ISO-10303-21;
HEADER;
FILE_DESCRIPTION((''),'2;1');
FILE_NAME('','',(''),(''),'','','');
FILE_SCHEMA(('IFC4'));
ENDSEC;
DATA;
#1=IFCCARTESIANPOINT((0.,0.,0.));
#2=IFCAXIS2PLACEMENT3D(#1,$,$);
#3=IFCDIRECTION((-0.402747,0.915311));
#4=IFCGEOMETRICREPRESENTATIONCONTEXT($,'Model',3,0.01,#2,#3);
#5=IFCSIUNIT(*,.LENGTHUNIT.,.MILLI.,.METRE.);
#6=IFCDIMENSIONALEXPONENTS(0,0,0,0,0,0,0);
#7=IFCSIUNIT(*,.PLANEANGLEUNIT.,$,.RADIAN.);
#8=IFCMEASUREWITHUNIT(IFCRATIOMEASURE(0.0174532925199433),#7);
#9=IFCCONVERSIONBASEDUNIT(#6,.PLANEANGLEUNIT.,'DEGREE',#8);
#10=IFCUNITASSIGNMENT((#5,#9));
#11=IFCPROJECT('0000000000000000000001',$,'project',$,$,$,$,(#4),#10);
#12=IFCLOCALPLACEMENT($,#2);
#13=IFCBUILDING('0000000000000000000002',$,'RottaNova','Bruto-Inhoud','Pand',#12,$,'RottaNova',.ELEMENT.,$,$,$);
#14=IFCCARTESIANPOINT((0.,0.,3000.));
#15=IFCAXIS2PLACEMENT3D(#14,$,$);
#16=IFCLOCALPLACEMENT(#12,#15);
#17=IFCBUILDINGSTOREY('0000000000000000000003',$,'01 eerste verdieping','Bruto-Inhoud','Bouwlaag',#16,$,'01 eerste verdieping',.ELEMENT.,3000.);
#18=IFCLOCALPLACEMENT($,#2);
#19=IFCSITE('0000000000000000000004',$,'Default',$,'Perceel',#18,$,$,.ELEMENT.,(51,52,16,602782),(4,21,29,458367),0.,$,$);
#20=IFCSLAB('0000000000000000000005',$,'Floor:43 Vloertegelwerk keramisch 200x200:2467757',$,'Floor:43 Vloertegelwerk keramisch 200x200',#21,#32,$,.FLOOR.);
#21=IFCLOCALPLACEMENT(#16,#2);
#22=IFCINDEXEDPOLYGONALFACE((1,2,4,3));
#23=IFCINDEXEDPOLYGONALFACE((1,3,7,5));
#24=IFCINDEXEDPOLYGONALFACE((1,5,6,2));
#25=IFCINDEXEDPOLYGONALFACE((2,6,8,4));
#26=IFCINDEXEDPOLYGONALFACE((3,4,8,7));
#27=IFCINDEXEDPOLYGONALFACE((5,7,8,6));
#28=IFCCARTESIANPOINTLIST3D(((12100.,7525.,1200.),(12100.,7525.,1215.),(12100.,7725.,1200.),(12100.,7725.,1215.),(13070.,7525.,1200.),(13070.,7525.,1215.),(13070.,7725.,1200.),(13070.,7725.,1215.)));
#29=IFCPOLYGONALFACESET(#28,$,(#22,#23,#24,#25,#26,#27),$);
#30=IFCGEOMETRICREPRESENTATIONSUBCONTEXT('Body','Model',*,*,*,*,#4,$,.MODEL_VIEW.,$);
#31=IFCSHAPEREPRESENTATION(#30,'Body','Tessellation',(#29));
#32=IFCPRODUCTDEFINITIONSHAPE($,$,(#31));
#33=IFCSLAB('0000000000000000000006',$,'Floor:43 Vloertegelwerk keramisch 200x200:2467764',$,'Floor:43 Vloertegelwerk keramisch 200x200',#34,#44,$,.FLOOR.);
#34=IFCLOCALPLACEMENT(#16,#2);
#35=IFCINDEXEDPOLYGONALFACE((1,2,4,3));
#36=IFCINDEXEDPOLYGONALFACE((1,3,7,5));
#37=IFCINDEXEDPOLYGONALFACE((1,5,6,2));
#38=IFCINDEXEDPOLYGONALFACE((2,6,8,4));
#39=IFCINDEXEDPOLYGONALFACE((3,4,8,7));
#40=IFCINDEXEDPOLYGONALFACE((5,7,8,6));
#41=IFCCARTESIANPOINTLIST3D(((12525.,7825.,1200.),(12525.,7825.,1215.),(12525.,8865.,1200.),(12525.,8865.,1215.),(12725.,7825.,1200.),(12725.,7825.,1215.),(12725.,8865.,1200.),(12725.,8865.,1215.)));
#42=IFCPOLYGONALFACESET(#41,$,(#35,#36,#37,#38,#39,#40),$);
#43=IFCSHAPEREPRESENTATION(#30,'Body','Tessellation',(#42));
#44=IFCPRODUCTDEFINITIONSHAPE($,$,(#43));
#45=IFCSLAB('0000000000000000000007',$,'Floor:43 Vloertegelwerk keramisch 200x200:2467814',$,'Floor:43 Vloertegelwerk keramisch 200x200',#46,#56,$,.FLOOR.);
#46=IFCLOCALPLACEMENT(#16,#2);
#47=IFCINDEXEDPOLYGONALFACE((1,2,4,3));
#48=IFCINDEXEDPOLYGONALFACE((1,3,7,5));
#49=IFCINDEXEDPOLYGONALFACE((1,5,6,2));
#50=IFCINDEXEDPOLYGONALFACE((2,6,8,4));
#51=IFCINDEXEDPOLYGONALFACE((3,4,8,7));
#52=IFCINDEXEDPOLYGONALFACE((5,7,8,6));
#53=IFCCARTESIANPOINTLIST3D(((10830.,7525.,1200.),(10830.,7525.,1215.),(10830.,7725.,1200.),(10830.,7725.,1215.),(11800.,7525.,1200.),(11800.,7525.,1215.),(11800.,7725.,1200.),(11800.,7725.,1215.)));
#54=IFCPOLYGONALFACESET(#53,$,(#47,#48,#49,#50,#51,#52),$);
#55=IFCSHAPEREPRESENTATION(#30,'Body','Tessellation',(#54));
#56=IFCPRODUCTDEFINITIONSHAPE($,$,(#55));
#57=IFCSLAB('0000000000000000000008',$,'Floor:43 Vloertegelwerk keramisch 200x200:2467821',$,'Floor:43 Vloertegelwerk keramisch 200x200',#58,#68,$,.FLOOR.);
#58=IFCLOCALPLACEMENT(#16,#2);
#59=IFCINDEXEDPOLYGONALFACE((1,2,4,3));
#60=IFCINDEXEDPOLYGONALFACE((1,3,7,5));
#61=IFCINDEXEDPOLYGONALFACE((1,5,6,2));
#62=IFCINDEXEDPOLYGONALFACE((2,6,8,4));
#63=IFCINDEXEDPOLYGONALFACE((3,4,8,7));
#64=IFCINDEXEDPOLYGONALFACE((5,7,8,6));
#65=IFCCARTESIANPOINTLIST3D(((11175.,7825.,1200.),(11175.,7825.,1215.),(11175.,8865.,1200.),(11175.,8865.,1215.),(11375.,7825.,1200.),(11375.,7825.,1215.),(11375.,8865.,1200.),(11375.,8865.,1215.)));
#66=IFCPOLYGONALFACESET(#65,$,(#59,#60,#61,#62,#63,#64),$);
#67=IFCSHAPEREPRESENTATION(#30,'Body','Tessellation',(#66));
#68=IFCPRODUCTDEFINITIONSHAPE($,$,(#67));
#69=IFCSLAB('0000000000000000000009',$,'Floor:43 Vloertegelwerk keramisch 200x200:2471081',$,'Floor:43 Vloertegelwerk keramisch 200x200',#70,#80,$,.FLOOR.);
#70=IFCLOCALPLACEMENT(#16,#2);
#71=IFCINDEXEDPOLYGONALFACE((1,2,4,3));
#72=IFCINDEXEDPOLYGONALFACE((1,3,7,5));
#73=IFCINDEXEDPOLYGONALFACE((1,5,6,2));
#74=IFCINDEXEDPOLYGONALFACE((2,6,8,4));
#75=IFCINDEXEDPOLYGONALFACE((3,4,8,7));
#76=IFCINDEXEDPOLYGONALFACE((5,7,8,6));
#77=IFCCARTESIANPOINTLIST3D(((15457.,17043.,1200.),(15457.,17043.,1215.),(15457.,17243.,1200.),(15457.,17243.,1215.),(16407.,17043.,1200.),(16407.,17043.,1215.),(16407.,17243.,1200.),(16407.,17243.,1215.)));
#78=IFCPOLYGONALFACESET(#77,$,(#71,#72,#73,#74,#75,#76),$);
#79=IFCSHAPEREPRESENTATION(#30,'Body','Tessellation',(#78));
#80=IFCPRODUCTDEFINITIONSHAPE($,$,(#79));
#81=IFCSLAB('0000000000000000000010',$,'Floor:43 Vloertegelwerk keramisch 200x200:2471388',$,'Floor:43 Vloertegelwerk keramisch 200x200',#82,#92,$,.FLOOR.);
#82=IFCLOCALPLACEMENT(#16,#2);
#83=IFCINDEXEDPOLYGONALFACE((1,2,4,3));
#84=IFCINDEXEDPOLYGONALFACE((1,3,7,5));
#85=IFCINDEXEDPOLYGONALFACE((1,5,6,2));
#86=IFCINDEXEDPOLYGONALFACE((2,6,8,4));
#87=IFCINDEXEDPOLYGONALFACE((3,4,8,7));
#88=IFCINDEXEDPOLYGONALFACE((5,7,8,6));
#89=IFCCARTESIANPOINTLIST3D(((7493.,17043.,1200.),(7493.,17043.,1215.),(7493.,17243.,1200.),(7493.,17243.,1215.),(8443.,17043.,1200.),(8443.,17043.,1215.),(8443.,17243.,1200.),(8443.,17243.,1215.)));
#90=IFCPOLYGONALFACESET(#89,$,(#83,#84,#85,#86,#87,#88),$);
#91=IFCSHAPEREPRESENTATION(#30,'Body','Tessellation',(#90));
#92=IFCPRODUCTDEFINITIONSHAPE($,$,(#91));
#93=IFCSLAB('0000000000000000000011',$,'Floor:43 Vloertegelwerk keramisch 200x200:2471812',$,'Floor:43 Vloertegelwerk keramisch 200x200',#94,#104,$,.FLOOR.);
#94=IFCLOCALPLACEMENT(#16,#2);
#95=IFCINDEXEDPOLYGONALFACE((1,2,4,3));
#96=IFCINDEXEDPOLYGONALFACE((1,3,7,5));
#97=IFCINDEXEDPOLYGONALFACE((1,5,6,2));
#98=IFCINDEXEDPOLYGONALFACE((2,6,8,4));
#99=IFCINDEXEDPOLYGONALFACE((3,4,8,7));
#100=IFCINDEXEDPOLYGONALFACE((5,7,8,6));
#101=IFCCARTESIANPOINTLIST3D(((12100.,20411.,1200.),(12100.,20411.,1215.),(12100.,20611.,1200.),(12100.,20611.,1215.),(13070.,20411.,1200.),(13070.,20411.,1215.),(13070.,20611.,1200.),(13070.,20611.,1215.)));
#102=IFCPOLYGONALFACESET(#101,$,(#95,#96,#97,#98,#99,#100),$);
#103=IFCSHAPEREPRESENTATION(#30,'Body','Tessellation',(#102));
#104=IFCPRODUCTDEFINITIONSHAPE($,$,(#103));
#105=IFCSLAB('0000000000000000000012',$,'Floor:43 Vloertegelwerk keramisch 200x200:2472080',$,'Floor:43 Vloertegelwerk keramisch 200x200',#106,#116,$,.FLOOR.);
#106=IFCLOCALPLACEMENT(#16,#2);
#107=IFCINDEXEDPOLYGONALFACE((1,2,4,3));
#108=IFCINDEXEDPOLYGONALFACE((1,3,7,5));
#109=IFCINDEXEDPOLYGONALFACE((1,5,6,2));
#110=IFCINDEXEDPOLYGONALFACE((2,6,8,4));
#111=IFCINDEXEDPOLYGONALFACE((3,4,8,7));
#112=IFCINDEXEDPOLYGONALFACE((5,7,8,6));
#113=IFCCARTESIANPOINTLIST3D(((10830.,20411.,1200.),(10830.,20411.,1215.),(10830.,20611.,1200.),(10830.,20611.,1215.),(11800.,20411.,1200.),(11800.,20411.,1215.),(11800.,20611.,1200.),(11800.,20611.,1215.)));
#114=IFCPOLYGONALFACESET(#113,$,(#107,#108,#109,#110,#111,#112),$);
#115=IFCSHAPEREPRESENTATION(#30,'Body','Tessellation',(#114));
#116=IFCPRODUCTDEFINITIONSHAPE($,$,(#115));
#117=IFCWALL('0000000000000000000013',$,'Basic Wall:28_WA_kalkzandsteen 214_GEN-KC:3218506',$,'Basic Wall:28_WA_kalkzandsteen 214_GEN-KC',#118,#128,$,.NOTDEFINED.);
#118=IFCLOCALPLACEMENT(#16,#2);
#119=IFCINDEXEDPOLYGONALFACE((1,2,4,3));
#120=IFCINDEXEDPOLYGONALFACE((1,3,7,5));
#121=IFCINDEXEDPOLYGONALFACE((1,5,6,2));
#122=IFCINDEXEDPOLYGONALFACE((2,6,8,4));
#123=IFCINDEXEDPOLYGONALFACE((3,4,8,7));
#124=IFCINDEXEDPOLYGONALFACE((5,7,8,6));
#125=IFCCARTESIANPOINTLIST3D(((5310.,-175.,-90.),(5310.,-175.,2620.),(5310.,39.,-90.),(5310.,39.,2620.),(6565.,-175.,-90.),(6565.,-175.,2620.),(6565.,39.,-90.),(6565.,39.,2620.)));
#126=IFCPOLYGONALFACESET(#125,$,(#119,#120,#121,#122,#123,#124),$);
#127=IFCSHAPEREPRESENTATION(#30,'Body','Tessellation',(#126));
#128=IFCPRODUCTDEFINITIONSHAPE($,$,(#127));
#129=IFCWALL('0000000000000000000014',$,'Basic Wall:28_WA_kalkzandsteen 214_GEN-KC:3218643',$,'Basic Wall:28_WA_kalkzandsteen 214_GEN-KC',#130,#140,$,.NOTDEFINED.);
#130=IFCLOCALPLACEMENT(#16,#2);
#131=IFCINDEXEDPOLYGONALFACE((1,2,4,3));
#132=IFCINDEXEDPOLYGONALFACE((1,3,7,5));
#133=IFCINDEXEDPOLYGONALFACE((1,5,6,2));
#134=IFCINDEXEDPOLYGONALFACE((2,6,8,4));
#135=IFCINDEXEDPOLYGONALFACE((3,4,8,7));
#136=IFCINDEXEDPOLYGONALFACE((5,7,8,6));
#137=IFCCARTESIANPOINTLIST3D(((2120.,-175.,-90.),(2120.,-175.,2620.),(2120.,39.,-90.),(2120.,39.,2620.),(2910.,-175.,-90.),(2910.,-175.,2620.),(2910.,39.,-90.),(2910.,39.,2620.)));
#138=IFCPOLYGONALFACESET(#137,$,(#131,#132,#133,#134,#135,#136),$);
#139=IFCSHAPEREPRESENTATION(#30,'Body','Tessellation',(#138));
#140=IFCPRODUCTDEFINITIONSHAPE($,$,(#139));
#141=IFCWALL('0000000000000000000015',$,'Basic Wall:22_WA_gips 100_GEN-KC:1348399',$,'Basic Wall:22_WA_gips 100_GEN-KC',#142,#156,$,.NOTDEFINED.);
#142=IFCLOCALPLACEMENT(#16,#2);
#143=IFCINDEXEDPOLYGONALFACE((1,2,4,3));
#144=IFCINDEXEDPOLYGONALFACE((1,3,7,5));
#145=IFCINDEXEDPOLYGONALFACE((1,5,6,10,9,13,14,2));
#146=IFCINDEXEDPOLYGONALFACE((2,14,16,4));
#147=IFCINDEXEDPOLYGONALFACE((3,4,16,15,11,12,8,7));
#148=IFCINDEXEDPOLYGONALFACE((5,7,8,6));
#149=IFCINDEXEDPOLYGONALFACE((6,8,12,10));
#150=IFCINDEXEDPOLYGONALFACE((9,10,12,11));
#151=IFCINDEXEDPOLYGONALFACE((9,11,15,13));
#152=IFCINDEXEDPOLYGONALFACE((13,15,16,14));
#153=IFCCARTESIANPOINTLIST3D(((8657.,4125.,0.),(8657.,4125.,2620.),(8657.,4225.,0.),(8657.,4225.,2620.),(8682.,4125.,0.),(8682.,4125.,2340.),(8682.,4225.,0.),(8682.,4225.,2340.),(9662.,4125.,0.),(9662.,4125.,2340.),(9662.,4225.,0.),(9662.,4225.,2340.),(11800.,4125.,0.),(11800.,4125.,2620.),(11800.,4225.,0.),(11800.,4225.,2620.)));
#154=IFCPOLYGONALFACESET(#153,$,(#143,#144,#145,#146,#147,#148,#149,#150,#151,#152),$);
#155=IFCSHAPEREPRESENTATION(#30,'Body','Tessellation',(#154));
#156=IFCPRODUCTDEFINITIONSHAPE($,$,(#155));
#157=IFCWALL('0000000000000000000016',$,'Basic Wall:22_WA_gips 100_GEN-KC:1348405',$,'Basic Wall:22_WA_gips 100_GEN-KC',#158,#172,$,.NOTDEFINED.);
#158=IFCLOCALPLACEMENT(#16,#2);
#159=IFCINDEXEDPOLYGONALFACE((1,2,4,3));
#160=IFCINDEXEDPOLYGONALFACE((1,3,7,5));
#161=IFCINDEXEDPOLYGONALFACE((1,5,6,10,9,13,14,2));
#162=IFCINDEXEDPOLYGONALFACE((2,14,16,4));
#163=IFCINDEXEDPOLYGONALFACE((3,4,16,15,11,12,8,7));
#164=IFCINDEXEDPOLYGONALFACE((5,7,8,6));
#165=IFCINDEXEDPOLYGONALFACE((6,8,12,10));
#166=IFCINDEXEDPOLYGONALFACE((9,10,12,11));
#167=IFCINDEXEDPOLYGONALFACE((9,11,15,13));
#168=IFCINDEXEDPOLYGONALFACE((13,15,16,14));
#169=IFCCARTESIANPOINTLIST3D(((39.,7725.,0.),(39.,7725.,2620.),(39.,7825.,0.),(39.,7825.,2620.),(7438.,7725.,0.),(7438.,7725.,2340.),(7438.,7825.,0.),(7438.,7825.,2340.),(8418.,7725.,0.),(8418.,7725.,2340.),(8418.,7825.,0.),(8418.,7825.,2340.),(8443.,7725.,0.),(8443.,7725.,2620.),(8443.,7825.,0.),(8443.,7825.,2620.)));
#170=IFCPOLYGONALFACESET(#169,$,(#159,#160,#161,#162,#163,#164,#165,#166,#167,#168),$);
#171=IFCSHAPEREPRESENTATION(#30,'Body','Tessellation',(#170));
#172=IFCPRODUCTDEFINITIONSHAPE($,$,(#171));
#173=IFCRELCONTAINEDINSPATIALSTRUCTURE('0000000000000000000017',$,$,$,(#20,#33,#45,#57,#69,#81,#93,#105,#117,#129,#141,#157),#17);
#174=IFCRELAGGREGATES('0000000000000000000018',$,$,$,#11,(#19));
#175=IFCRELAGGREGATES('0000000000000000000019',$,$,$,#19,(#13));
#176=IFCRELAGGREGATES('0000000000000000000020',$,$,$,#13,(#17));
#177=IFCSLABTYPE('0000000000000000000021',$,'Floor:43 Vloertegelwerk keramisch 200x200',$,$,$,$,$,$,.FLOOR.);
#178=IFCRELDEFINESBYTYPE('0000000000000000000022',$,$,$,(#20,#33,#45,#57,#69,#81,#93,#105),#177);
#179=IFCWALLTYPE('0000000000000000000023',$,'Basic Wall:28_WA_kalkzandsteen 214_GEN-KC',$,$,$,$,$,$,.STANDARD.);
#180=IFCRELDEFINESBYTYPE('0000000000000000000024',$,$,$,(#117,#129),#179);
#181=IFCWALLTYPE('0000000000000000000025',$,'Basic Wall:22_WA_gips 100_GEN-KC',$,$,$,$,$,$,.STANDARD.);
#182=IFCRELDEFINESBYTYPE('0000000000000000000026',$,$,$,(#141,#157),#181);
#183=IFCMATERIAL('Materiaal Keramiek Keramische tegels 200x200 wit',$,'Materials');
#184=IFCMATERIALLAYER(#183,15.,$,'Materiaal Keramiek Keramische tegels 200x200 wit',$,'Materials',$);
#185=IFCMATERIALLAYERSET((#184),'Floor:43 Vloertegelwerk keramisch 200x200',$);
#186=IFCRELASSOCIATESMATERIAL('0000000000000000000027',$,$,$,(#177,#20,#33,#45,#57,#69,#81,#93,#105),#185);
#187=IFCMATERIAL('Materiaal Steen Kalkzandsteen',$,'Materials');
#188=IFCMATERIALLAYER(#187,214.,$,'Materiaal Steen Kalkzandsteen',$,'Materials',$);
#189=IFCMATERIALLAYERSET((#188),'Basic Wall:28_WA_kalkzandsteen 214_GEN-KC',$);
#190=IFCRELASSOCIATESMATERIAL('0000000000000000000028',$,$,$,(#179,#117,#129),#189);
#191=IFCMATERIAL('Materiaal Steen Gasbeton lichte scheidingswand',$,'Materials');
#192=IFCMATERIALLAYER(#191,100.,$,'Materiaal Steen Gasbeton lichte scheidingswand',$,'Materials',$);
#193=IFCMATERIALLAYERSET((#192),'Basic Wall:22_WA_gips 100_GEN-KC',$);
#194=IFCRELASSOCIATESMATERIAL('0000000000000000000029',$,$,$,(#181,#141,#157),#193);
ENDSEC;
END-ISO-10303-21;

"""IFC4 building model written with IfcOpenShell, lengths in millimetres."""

from ifc_helpers import new_model, entity, si_unit, converted_unit, direction, frame, frame_2d, origin, origin_2d_with_axis, place, context, subcontext, project, spatial, rectangle, extrude, material, layer, layer_set, layer_usage, type_object, element, save


model = new_model("IFC4")

# Units and contexts
model_context = context("Model", 3, precision=0.01, world=origin(), true_north=direction((-0.402747, 0.915311)))
body_context = subcontext(model_context, "Body", "Model", "MODEL_VIEW")
ifc_project = project(units=[si_unit("LENGTHUNIT", "METRE", prefix="MILLI"), converted_unit("PLANEANGLEUNIT", "DEGREE", entity("IfcRatioMeasure", 0.0174532925199433), si_unit("PLANEANGLEUNIT", "RADIAN"), dimensions=[0, 0, 0, 0, 0, 0, 0])], contexts=[model_context])

# Site, building, storey
site_placement = place(None, origin())
site = spatial("IfcSite", under=ifc_project, at=site_placement, Name="Default", ObjectType="Perceel", CompositionType="ELEMENT", RefLatitude=(51, 52, 16, 602782), RefLongitude=(4, 21, 29, 458367), RefElevation=0.0)
building_placement = place(None, origin())
building = spatial("IfcBuilding", under=site, at=building_placement, Name="RottaNova", Description="Bruto-Inhoud", ObjectType="Pand", LongName="RottaNova", CompositionType="ELEMENT")
storey_placement = place(building_placement, frame((0.0, 0.0, 3000.0)))
storey = spatial("IfcBuildingStorey", under=building, at=storey_placement, Name="01 eerste verdieping", Description="Bruto-Inhoud", ObjectType="Bouwlaag", LongName="01 eerste verdieping", CompositionType="ELEMENT", Elevation=3000.0)

# Slabs
ifc_material_1 = material(Name="Materiaal Keramiek Keramische tegels 200x200 wit", Category="Materials")
ifc_layer_1 = layer(ifc_material_1, 15.0, Name="Materiaal Keramiek Keramische tegels 200x200 wit", Category="Materials")
ifc_layer_set_1 = layer_set([ifc_layer_1], Name="Floor:43 Vloertegelwerk keramisch 200x200")
ifc_layer_usage_1 = layer_usage(ifc_layer_set_1, "AXIS3", "POSITIVE", 0.0)
slab_type_1 = type_object("IfcSlabType", Name="Floor:43 Vloertegelwerk keramisch 200x200", PredefinedType="FLOOR", material=ifc_layer_set_1)
slab_1_placement = place(storey_placement, origin())
element("IfcSlab", 1, at=slab_1_placement, inside=storey, type_object=slab_type_1, material=ifc_layer_usage_1, Name="Floor:43 Vloertegelwerk keramisch 200x200:2467757", ObjectType="Floor:43 Vloertegelwerk keramisch 200x200", PredefinedType="FLOOR", context=body_context, shape_type="SweptSolid", body=[
    extrude(rectangle(XDim=200.0, YDim=970.0, at=origin_2d_with_axis()), frame((12585.0, 7625.0, 1215.0), z_axis=(0.0, 0.0, -1.0), x_axis=(0.0, 1.0, 0.0)), (0.0, 0.0, 1.0), 15.0),
])
slab_2_placement = place(storey_placement, origin())
element("IfcSlab", 2, at=slab_2_placement, inside=storey, type_object=slab_type_1, material=ifc_layer_usage_1, Name="Floor:43 Vloertegelwerk keramisch 200x200:2467764", ObjectType="Floor:43 Vloertegelwerk keramisch 200x200", PredefinedType="FLOOR", context=body_context, shape_type="SweptSolid", body=[
    extrude(rectangle(XDim=1040.0, YDim=200.0, at=origin_2d_with_axis()), frame((12625.0, 8345.0, 1215.0), z_axis=(0.0, 0.0, -1.0), x_axis=(0.0, 1.0, 0.0)), (0.0, 0.0, 1.0), 15.0),
])
slab_3_placement = place(storey_placement, origin())
element("IfcSlab", 3, at=slab_3_placement, inside=storey, type_object=slab_type_1, material=ifc_layer_usage_1, Name="Floor:43 Vloertegelwerk keramisch 200x200:2467814", ObjectType="Floor:43 Vloertegelwerk keramisch 200x200", PredefinedType="FLOOR", context=body_context, shape_type="SweptSolid", body=[
    extrude(rectangle(XDim=200.0, YDim=970.0, at=origin_2d_with_axis()), frame((11315.0, 7625.0, 1215.0), z_axis=(0.0, 0.0, -1.0), x_axis=(0.0, 1.0, 0.0)), (0.0, 0.0, 1.0), 15.0),
])
slab_4_placement = place(storey_placement, origin())
element("IfcSlab", 4, at=slab_4_placement, inside=storey, type_object=slab_type_1, material=ifc_layer_usage_1, Name="Floor:43 Vloertegelwerk keramisch 200x200:2467821", ObjectType="Floor:43 Vloertegelwerk keramisch 200x200", PredefinedType="FLOOR", context=body_context, shape_type="SweptSolid", body=[
    extrude(rectangle(XDim=1040.0, YDim=200.0, at=origin_2d_with_axis()), frame((11275.0, 8345.0, 1215.0), z_axis=(0.0, 0.0, -1.0), x_axis=(0.0, 1.0, 0.0)), (0.0, 0.0, 1.0), 15.0),
])
slab_5_placement = place(storey_placement, origin())
element("IfcSlab", 5, at=slab_5_placement, inside=storey, type_object=slab_type_1, material=ifc_layer_usage_1, Name="Floor:43 Vloertegelwerk keramisch 200x200:2471081", ObjectType="Floor:43 Vloertegelwerk keramisch 200x200", PredefinedType="FLOOR", context=body_context, shape_type="SweptSolid", body=[
    extrude(rectangle(XDim=200.0, YDim=950.0, at=frame_2d((0.0, 0.0), x_axis=(1.0, 0.0))), frame((15932.0, 17143.0, 1215.0), z_axis=(0.0, 0.0, -1.0), x_axis=(0.0, 1.0, 0.0)), (0.0, 0.0, 1.0), 15.0),
])
slab_6_placement = place(storey_placement, origin())
element("IfcSlab", 6, at=slab_6_placement, inside=storey, type_object=slab_type_1, material=ifc_layer_usage_1, Name="Floor:43 Vloertegelwerk keramisch 200x200:2471388", ObjectType="Floor:43 Vloertegelwerk keramisch 200x200", PredefinedType="FLOOR", context=body_context, shape_type="SweptSolid", body=[
    extrude(rectangle(XDim=200.0, YDim=950.0, at=frame_2d((0.0, 0.0), x_axis=(1.0, 0.0))), frame((7968.0, 17143.0, 1215.0), z_axis=(0.0, 0.0, -1.0), x_axis=(0.0, 1.0, 0.0)), (0.0, 0.0, 1.0), 15.0),
])
slab_7_placement = place(storey_placement, origin())
element("IfcSlab", 7, at=slab_7_placement, inside=storey, type_object=slab_type_1, material=ifc_layer_usage_1, Name="Floor:43 Vloertegelwerk keramisch 200x200:2471812", ObjectType="Floor:43 Vloertegelwerk keramisch 200x200", PredefinedType="FLOOR", context=body_context, shape_type="SweptSolid", body=[
    extrude(rectangle(XDim=200.0, YDim=970.0, at=origin_2d_with_axis()), frame((12585.0, 20511.0, 1215.0), z_axis=(0.0, 0.0, -1.0), x_axis=(0.0, 1.0, 0.0)), (0.0, 0.0, 1.0), 15.0),
])
slab_8_placement = place(storey_placement, origin())
element("IfcSlab", 8, at=slab_8_placement, inside=storey, type_object=slab_type_1, material=ifc_layer_usage_1, Name="Floor:43 Vloertegelwerk keramisch 200x200:2472080", ObjectType="Floor:43 Vloertegelwerk keramisch 200x200", PredefinedType="FLOOR", context=body_context, shape_type="SweptSolid", body=[
    extrude(rectangle(XDim=200.0, YDim=970.0, at=origin_2d_with_axis()), frame((11315.0, 20511.0, 1215.0), z_axis=(0.0, 0.0, -1.0), x_axis=(0.0, 1.0, 0.0)), (0.0, 0.0, 1.0), 15.0),
])

# Walls
ifc_material_2 = material(Name="Materiaal Steen Kalkzandsteen", Category="Materials")
ifc_layer_2 = layer(ifc_material_2, 214.0, Name="Materiaal Steen Kalkzandsteen", Category="Materials")
ifc_layer_set_2 = layer_set([ifc_layer_2], Name="Basic Wall:28_WA_kalkzandsteen 214_GEN-KC")
wall_type_1 = type_object("IfcWallType", Name="Basic Wall:28_WA_kalkzandsteen 214_GEN-KC", PredefinedType="STANDARD", material=ifc_layer_set_2)
wall_1_placement = place(storey_placement, frame((6565.0, -68.0, -90.0), z_axis=(0.0, 0.0, 1.0), x_axis=(-1.0, 0.0, 0.0)))
element("IfcWall", 9, at=wall_1_placement, inside=storey, type_object=wall_type_1, material=ifc_layer_set_2, Name="Basic Wall:28_WA_kalkzandsteen 214_GEN-KC:3218506", ObjectType="Basic Wall:28_WA_kalkzandsteen 214_GEN-KC", PredefinedType="NOTDEFINED", context=body_context, shape_type="SweptSolid", body=[
    extrude(rectangle(XDim=1255.0, YDim=214.0, at=frame_2d((627.5, 0.0), x_axis=(-1.0, 0.0))), origin(), (0.0, 0.0, 1.0), 2710.0),
])
wall_2_placement = place(storey_placement, frame((2910.0, -68.0, -90.0), z_axis=(0.0, 0.0, 1.0), x_axis=(-1.0, 0.0, 0.0)))
element("IfcWall", 10, at=wall_2_placement, inside=storey, type_object=wall_type_1, material=ifc_layer_set_2, Name="Basic Wall:28_WA_kalkzandsteen 214_GEN-KC:3218643", ObjectType="Basic Wall:28_WA_kalkzandsteen 214_GEN-KC", PredefinedType="NOTDEFINED", context=body_context, shape_type="SweptSolid", body=[
    extrude(rectangle(XDim=790.0, YDim=214.0, at=frame_2d((395.0, 0.0), x_axis=(-1.0, 0.0))), origin(), (0.0, 0.0, 1.0), 2710.0),
])

# Walls, openings
ifc_material_3 = material(Name="Materiaal Steen Gasbeton lichte scheidingswand", Category="Materials")
ifc_layer_3 = layer(ifc_material_3, 100.0, Name="Materiaal Steen Gasbeton lichte scheidingswand", Category="Materials")
ifc_layer_set_3 = layer_set([ifc_layer_3], Name="Basic Wall:22_WA_gips 100_GEN-KC")
wall_type_2 = type_object("IfcWallType", Name="Basic Wall:22_WA_gips 100_GEN-KC", PredefinedType="STANDARD", material=ifc_layer_set_3)
wall_3_placement = place(storey_placement, frame((8657.0, 4175.0, 0.0)))
wall_3 = element("IfcWall", 11, at=wall_3_placement, inside=storey, type_object=wall_type_2, material=ifc_layer_set_3, Name="Basic Wall:22_WA_gips 100_GEN-KC:1348399", ObjectType="Basic Wall:22_WA_gips 100_GEN-KC", PredefinedType="NOTDEFINED", context=body_context, shape_type="SweptSolid", body=[
    extrude(rectangle(XDim=3143.0, YDim=100.0, at=frame_2d((1571.5, 0.0), x_axis=(-1.0, 0.0))), origin(), (0.0, 0.0, 1.0), 2620.0),
])
opening_1_placement = place(wall_3_placement, frame((1005.0, 50.0, -90.0)))
element("IfcOpeningElement", 12, at=opening_1_placement, cuts=wall_3, PredefinedType="OPENING", context=body_context, shape_type="SweptSolid", body=[
    extrude(rectangle(XDim=2430.0, YDim=980.0, at=frame_2d((1215.0, 490.0), x_axis=(1.0, 0.0))), frame((0.0, 0.0, 0.0), z_axis=(0.0, -1.0, 0.0), x_axis=(0.0, 0.0, 1.0)), (0.0, 0.0, 1.0), 100.0),
])
wall_4_placement = place(storey_placement, frame((39.0, 7775.0, 0.0)))
wall_4 = element("IfcWall", 13, at=wall_4_placement, inside=storey, type_object=wall_type_2, material=ifc_layer_set_3, Name="Basic Wall:22_WA_gips 100_GEN-KC:1348405", ObjectType="Basic Wall:22_WA_gips 100_GEN-KC", PredefinedType="NOTDEFINED", context=body_context, shape_type="SweptSolid", body=[
    extrude(rectangle(XDim=8404.0, YDim=100.0, at=frame_2d((4202.0, 0.0), x_axis=(1.0, 0.0))), origin(), (0.0, 0.0, 1.0), 2620.0),
])
opening_2_placement = place(wall_4_placement, frame((8379.0, 50.0, -90.0)))
element("IfcOpeningElement", 14, at=opening_2_placement, cuts=wall_4, PredefinedType="OPENING", context=body_context, shape_type="SweptSolid", body=[
    extrude(rectangle(XDim=2430.0, YDim=980.0, at=frame_2d((1215.0, 490.0), x_axis=(1.0, 0.0))), frame((0.0, 0.0, 0.0), z_axis=(0.0, -1.0, 0.0), x_axis=(0.0, 0.0, 1.0)), (0.0, 0.0, 1.0), 100.0),
])

save(model, "model.ifc")
